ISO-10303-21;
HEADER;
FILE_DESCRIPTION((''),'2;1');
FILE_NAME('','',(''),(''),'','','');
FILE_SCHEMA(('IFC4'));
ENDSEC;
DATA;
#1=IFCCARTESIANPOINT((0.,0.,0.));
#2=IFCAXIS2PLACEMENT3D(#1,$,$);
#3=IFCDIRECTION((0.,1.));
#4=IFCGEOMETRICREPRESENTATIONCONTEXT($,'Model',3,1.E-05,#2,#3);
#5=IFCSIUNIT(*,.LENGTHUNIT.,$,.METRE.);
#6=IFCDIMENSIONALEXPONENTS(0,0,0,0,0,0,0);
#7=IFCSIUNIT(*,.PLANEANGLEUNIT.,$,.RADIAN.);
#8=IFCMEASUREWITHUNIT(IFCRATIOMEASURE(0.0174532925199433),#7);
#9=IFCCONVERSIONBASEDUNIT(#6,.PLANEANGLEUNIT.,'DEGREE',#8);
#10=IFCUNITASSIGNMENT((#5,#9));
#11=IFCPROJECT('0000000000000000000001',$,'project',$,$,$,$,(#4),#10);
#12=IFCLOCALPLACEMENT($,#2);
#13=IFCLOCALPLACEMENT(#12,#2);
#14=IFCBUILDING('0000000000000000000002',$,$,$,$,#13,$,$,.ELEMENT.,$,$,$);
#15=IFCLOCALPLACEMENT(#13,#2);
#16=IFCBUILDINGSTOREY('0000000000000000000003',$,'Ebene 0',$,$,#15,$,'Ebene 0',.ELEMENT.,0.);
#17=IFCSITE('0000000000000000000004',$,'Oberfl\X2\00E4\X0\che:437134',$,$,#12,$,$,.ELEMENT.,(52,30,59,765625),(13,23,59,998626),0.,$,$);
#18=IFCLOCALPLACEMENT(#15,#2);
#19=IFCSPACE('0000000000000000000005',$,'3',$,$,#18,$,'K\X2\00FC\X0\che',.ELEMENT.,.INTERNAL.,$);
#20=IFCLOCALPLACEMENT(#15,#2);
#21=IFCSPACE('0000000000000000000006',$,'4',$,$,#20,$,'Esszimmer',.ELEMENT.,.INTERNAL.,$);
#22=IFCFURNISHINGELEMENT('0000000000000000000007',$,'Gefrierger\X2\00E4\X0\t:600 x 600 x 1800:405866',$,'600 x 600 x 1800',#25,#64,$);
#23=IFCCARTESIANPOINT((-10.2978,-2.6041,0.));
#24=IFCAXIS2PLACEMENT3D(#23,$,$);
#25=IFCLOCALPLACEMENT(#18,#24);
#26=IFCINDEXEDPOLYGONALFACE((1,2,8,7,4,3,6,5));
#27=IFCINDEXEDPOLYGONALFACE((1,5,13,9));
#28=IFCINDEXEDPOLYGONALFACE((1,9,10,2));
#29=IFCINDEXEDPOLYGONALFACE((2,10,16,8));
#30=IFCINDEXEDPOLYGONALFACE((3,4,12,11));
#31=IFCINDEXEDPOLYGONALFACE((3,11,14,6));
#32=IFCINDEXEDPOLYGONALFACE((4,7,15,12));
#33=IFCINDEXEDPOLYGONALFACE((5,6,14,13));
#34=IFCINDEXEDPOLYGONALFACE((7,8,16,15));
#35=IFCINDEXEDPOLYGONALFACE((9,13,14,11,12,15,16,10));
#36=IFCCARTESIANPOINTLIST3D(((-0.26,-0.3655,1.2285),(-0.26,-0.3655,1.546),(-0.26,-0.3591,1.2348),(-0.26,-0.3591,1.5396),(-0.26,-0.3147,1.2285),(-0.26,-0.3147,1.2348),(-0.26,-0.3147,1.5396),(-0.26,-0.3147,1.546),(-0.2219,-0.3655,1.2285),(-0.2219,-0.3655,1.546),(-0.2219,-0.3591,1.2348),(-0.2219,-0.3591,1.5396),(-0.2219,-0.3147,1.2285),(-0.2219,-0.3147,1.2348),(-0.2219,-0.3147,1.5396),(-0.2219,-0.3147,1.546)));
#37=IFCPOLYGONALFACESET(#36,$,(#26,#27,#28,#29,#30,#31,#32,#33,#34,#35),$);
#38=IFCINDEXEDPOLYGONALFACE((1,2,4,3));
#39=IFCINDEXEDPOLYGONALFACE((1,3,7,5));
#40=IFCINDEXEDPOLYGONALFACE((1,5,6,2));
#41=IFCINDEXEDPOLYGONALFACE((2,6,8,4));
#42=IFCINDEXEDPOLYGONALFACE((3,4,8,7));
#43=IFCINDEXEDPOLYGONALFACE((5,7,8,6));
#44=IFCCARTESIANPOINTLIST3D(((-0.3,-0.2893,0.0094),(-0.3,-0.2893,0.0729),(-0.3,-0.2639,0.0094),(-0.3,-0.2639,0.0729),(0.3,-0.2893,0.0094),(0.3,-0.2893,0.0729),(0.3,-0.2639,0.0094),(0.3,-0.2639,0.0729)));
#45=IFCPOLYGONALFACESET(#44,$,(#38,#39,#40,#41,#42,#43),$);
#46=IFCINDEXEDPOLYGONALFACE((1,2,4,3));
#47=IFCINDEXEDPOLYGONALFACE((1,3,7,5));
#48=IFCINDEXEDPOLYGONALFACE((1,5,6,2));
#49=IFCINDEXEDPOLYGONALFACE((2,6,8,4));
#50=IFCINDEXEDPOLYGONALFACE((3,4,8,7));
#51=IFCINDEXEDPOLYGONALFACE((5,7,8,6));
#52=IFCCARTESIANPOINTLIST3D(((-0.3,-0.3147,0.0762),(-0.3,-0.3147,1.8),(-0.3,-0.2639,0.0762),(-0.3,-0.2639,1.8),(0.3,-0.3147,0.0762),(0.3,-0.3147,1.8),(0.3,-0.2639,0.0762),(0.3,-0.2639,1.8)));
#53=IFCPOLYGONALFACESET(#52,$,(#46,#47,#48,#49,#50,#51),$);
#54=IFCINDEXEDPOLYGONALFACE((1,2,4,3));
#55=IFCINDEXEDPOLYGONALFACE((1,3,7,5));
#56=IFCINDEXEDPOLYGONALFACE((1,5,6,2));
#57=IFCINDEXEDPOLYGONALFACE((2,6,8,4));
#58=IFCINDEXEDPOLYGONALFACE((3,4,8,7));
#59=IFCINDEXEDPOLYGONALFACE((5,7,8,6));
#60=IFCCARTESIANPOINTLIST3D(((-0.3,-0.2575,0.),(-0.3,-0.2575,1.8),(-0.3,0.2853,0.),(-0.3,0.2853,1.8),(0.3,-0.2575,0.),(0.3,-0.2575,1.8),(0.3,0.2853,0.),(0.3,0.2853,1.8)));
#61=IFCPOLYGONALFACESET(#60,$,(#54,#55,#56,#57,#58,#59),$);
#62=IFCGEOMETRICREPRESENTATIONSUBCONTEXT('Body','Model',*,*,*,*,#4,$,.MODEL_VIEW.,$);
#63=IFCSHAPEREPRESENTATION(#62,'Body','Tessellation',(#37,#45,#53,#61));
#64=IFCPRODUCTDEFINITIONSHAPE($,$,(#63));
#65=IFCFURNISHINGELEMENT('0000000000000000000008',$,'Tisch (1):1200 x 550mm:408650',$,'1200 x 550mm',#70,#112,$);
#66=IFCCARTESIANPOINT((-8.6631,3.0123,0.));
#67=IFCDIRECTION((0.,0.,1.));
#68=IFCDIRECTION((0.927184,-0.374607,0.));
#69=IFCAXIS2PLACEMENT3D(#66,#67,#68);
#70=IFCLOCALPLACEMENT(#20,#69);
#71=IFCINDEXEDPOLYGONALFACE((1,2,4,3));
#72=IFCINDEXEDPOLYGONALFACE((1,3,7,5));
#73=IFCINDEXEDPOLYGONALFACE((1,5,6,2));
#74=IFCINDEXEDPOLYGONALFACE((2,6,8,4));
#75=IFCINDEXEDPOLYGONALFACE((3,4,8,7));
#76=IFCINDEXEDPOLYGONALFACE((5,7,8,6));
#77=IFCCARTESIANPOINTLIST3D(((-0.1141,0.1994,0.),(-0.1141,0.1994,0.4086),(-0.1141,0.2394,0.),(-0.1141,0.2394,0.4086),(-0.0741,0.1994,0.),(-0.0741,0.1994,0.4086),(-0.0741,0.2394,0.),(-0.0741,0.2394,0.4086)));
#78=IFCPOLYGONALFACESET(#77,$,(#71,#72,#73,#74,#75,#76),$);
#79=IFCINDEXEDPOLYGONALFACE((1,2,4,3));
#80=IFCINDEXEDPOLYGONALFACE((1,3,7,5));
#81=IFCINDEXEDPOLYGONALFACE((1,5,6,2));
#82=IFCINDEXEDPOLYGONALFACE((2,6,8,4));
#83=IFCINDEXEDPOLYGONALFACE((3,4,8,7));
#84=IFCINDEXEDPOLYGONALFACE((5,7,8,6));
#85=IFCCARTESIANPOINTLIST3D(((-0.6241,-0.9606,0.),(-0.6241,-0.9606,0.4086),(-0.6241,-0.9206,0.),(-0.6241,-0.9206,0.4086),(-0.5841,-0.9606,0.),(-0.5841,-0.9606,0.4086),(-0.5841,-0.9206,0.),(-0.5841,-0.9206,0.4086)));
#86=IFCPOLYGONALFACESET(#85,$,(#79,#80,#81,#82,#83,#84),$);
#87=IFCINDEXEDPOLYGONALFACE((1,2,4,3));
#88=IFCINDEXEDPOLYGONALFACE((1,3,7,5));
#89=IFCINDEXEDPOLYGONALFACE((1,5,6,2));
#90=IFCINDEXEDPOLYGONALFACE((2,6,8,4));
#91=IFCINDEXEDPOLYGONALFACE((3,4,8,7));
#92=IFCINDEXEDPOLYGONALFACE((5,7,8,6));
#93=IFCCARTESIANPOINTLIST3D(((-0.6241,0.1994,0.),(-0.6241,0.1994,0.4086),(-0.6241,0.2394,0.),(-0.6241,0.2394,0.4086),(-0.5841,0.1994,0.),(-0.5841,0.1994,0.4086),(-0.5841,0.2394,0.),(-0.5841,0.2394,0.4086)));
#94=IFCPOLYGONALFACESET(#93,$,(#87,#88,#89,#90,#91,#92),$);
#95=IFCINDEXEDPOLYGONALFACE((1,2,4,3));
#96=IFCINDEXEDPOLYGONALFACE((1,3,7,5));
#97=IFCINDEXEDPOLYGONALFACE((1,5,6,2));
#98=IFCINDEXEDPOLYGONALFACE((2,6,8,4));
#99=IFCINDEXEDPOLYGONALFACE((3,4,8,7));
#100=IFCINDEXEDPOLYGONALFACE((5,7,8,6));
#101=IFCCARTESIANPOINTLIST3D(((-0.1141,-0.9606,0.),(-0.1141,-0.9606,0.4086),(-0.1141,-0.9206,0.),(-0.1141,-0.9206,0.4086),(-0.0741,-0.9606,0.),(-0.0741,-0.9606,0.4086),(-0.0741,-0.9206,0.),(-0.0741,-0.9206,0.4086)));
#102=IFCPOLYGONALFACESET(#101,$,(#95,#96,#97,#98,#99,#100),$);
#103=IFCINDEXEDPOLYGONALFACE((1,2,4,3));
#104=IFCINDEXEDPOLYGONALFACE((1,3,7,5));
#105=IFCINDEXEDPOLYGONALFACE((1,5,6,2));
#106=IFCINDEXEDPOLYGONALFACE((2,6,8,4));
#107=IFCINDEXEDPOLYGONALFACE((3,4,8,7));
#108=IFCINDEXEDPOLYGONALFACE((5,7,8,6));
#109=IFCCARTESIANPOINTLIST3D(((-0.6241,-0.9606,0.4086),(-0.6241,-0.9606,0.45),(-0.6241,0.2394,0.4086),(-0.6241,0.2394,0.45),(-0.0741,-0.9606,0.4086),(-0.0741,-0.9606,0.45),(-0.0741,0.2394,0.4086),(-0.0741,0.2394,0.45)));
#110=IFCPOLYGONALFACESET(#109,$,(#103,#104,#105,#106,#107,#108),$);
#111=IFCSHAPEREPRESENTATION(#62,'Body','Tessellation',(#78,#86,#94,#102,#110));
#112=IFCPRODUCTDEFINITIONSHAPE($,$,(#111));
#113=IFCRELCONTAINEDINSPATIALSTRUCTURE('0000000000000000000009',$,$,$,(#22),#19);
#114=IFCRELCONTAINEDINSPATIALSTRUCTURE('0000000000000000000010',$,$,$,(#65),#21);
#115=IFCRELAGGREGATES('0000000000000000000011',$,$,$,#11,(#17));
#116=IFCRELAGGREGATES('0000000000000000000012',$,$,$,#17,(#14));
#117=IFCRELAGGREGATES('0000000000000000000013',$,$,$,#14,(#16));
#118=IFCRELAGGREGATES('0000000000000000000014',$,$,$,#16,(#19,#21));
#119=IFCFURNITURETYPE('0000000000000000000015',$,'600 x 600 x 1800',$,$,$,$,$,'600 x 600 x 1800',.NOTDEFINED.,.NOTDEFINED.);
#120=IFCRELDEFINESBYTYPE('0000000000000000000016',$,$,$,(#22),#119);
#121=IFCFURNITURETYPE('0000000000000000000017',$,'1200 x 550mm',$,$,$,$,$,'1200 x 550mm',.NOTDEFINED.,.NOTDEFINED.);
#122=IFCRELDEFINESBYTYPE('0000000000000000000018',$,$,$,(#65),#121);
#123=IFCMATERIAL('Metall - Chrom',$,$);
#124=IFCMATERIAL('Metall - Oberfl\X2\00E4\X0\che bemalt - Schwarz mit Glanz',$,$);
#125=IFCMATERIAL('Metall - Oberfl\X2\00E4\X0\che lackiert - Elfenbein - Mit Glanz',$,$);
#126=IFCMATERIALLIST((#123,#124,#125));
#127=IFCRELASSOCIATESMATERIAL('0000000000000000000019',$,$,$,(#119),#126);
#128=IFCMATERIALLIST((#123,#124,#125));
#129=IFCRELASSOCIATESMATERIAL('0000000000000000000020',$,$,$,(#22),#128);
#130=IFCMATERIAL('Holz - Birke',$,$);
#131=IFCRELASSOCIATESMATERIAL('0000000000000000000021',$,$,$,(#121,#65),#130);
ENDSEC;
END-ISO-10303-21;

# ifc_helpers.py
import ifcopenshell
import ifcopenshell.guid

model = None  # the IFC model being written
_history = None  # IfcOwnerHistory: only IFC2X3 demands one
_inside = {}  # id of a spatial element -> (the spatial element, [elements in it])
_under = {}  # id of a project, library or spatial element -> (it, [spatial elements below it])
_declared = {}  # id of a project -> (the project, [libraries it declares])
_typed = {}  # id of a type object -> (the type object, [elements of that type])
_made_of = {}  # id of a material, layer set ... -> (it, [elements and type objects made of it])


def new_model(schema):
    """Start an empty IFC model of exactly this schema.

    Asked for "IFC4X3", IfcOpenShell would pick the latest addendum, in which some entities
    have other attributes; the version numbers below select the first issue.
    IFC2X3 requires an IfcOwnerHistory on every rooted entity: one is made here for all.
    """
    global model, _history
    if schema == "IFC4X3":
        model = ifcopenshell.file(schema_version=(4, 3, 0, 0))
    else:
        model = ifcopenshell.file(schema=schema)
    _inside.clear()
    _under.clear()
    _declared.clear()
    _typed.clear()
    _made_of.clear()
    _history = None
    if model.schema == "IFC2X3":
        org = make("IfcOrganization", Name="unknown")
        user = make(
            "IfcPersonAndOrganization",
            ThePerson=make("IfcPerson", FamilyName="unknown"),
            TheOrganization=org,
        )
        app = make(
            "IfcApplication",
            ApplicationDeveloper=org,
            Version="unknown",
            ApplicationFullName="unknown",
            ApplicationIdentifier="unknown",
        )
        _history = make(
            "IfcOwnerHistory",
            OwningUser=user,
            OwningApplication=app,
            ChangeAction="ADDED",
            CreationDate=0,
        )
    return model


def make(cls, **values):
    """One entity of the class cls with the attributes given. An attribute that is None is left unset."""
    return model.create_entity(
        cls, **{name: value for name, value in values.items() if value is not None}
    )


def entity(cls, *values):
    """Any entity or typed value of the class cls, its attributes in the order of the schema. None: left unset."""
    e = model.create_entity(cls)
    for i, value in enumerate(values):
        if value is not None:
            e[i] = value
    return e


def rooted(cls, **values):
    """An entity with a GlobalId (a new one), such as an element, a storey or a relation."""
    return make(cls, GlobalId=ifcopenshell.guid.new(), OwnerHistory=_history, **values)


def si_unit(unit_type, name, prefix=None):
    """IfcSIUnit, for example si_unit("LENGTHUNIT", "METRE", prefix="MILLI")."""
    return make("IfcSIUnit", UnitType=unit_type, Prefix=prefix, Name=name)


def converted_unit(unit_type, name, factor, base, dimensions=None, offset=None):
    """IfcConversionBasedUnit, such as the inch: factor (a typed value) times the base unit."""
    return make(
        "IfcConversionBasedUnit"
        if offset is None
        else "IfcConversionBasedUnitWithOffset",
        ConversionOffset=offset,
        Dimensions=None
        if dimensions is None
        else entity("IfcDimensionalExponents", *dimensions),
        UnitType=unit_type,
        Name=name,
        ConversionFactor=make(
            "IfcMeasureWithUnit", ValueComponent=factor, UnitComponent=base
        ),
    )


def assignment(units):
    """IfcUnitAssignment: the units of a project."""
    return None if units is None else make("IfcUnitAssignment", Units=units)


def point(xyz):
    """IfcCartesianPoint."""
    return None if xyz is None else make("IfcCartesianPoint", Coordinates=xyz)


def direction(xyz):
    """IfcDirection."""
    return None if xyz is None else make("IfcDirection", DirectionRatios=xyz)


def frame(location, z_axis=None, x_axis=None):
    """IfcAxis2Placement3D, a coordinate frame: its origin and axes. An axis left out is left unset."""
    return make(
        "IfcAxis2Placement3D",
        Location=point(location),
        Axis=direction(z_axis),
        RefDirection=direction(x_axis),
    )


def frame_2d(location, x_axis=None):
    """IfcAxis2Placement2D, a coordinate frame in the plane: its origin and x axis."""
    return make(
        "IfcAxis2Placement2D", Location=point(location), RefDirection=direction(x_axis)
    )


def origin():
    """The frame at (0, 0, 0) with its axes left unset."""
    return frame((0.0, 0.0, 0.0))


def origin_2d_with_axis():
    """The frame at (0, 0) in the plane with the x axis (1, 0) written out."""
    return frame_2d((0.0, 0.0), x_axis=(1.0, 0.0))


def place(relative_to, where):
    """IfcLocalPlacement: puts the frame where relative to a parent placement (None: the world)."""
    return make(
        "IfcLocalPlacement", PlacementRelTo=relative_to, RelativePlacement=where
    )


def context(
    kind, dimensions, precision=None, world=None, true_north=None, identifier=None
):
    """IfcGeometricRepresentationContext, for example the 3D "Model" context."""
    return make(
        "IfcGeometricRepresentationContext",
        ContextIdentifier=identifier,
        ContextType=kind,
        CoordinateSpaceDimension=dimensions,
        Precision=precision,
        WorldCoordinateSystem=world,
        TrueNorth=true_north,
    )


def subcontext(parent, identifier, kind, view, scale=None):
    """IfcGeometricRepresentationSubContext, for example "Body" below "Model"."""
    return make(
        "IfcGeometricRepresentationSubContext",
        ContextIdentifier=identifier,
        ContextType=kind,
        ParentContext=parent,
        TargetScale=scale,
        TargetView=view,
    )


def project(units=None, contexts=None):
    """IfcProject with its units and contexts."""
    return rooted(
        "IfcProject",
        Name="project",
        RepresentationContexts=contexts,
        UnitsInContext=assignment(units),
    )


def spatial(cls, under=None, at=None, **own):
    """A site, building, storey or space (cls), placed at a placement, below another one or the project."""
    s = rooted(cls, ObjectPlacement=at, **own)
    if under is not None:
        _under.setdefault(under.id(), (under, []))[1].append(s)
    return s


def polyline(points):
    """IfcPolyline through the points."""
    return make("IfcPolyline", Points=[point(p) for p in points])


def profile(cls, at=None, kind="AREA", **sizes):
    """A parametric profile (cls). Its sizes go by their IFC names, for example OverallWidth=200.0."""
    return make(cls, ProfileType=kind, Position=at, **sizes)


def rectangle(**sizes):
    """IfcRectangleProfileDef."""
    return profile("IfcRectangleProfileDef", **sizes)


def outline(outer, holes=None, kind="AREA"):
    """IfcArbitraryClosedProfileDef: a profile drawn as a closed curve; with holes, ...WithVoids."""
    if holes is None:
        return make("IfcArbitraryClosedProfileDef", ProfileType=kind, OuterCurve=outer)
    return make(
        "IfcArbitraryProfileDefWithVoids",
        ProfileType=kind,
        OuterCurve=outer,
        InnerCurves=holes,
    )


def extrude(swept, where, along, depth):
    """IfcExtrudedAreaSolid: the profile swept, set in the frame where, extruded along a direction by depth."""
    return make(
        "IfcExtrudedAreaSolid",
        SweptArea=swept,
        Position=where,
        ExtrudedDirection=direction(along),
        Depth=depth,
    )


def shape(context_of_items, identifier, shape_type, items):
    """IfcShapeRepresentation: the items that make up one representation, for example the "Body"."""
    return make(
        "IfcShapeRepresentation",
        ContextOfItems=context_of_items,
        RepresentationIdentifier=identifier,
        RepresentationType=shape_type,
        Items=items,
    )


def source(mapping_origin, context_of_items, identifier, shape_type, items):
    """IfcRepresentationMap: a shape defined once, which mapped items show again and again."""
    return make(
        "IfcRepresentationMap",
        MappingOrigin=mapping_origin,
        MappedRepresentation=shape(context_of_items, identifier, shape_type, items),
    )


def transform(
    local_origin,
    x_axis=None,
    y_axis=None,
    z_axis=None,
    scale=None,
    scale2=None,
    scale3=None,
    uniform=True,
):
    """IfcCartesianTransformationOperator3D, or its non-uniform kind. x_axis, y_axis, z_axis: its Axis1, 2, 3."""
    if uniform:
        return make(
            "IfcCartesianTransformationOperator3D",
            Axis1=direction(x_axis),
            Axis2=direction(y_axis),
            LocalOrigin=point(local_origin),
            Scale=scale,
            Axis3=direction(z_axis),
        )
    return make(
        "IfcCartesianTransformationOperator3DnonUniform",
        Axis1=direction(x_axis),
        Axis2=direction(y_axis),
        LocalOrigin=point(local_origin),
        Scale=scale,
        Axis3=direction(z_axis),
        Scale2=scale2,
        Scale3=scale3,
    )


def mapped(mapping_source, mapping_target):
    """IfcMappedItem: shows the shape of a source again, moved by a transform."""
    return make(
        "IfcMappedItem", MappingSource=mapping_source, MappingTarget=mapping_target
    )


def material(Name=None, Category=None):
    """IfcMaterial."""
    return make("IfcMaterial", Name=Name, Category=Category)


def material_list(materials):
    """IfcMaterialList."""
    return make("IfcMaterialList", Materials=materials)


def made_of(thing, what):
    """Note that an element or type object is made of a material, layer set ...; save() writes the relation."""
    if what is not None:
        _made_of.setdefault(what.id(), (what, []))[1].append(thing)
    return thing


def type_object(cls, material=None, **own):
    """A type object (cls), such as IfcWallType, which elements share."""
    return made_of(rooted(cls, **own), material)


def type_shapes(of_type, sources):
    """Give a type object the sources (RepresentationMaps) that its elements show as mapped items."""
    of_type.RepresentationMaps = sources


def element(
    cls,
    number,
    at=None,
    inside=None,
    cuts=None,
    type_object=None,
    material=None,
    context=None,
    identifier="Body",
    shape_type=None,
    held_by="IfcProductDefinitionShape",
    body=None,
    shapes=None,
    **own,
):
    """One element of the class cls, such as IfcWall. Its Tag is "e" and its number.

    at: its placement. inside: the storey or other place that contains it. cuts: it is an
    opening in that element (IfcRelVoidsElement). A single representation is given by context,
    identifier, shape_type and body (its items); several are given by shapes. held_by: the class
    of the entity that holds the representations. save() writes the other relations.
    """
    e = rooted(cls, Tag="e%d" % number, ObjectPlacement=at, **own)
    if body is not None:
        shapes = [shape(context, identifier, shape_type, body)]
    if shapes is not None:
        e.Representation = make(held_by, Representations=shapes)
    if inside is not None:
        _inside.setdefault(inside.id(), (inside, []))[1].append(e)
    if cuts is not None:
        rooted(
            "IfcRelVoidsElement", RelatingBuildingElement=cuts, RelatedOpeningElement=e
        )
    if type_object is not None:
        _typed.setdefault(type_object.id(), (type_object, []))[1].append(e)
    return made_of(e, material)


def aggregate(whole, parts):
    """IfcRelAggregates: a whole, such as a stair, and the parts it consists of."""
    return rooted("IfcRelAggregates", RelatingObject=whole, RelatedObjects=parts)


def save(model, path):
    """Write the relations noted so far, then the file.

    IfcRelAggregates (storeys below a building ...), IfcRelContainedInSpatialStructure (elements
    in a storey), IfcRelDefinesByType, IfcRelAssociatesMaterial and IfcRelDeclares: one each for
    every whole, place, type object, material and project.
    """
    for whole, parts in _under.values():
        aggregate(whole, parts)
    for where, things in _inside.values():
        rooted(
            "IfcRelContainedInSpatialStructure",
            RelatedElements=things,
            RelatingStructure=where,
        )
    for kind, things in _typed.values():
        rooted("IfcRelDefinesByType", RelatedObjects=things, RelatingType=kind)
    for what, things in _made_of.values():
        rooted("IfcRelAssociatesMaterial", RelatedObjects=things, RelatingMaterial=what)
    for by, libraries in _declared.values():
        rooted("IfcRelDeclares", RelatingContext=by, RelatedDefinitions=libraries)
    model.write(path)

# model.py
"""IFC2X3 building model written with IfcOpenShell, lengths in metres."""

from ifc_helpers import new_model, entity, si_unit, converted_unit, direction, frame, frame_2d, origin, origin_2d_with_axis, place, context, subcontext, project, spatial, polyline, rectangle, outline, extrude, source, transform, mapped, material, material_list, type_object, type_shapes, element, save


model = new_model("IFC2X3")

# Units and contexts
model_context = context("Model", 3, precision=1e-05, world=origin(), true_north=direction((0.0, 1.0)))
body_context = subcontext(model_context, "Body", "Model", "MODEL_VIEW")
ifc_project = project(units=[si_unit("LENGTHUNIT", "METRE"), converted_unit("PLANEANGLEUNIT", "DEGREE", entity("IfcRatioMeasure", 0.0174532925199433), si_unit("PLANEANGLEUNIT", "RADIAN"), dimensions=[0, 0, 0, 0, 0, 0, 0])], contexts=[model_context])

# Site, building, storey
site_placement = place(None, origin())
site = spatial("IfcSite", under=ifc_project, at=site_placement, Name="Oberfläche:437134", CompositionType="ELEMENT", RefLatitude=(52, 30, 59, 765625), RefLongitude=(13, 23, 59, 998626), RefElevation=0.0)
building_placement = place(site_placement, origin())
building = spatial("IfcBuilding", under=site, at=building_placement, CompositionType="ELEMENT")
storey_placement = place(building_placement, origin())
storey = spatial("IfcBuildingStorey", under=building, at=storey_placement, Name="Ebene 0", LongName="Ebene 0", CompositionType="ELEMENT", Elevation=0.0)

# Shared definitions
space_1_placement = place(storey_placement, origin())
space_1 = spatial("IfcSpace", under=storey, at=space_1_placement, Name="3", LongName="Küche", CompositionType="ELEMENT", InteriorOrExteriorSpace="INTERNAL")

# Furnishing element
ifc_material_1 = material(Name="Metall - Chrom")
ifc_material_2 = material(Name="Metall - Oberfläche bemalt - Schwarz mit Glanz")
ifc_material_3 = material(Name="Metall - Oberfläche lackiert - Elfenbein - Mit Glanz")
ifc_material_list_1 = material_list([ifc_material_1, ifc_material_2, ifc_material_3])
ifc_material_list_2 = material_list([ifc_material_1, ifc_material_2, ifc_material_3])
furniture_type_1 = type_object("IfcFurnitureType", Name="600 x 600 x 1800", ElementType="600 x 600 x 1800", material=ifc_material_list_2)
shared_shape_1 = source(origin(), body_context, "Body", "SweptSolid", [
    extrude(outline(polyline([(0.1524, -0.0238), (0.1587, -0.0238), (0.1587, 0.027), (-0.1587, 0.027), (-0.1587, -0.0238), (-0.1524, -0.0238), (-0.1524, 0.0206), (0.1524, 0.0206), (0.1524, -0.0238)])), frame((-0.26, -0.3385, 1.3873), z_axis=(1.0, 0.0, 0.0), x_axis=(0.0, 0.0, 1.0)), (0.0, 0.0, 1.0), 0.0381),
    extrude(rectangle(XDim=0.6, YDim=0.0254, at=frame_2d((0.0, 0.0), x_axis=(1.0, 0.0))), frame((0.0, -0.2766, 0.0094), z_axis=(0.0, 0.0, 1.0), x_axis=(-1.0, 0.0, 0.0)), (0.0, 0.0, 1.0), 0.0635),
    extrude(rectangle(XDim=0.6, YDim=0.0508, at=origin_2d_with_axis()), frame((0.0, -0.2893, 0.0762), z_axis=(0.0, 0.0, 1.0), x_axis=(-1.0, 0.0, 0.0)), (0.0, 0.0, 1.0), 1.7238),
    extrude(rectangle(XDim=0.6, YDim=0.5429, at=frame_2d((0.0, 0.0), x_axis=(1.0, 0.0))), frame((0.0, 0.0139, 0.0), z_axis=(0.0, 0.0, 1.0), x_axis=(-1.0, 0.0, 0.0)), (0.0, 0.0, 1.0), 1.8),
])
type_shapes(furniture_type_1, [shared_shape_1])
furnishing_1_placement = place(space_1_placement, frame((-10.2978, -2.6041, 0.0)))
element("IfcFurnishingElement", 1, at=furnishing_1_placement, inside=space_1, type_object=furniture_type_1, material=ifc_material_list_1, Name="Gefriergerät:600 x 600 x 1800:405866", ObjectType="600 x 600 x 1800", context=body_context, shape_type="MappedRepresentation", body=[
    mapped(shared_shape_1, transform((0.0, 0.0, 0.0), scale=1.0)),
])

# Shared definitions
space_2_placement = place(storey_placement, origin())
space_2 = spatial("IfcSpace", under=storey, at=space_2_placement, Name="4", LongName="Esszimmer", CompositionType="ELEMENT", InteriorOrExteriorSpace="INTERNAL")

# Furnishing element
ifc_material_4 = material(Name="Holz - Birke")
furniture_type_2 = type_object("IfcFurnitureType", Name="1200 x 550mm", ElementType="1200 x 550mm", material=ifc_material_4)
shared_shape_2 = source(origin(), body_context, "Body", "SweptSolid", [
    extrude(rectangle(XDim=0.04, YDim=0.04, at=origin_2d_with_axis()), frame((-0.0941, 0.2194, 0.0), z_axis=(0.0, 0.0, 1.0), x_axis=(-1.0, 0.0, 0.0)), (0.0, 0.0, 1.0), 0.4086),
    extrude(rectangle(XDim=0.04, YDim=0.04, at=frame_2d((0.0, 0.0), x_axis=(1.0, 0.0))), frame((-0.6041, -0.9406, 0.0), z_axis=(0.0, 0.0, 1.0), x_axis=(0.0, -1.0, 0.0)), (0.0, 0.0, 1.0), 0.4086),
    extrude(rectangle(XDim=0.04, YDim=0.04, at=origin_2d_with_axis()), frame((-0.6041, 0.2194, 0.0), z_axis=(0.0, 0.0, 1.0), x_axis=(-1.0, 0.0, 0.0)), (0.0, 0.0, 1.0), 0.4086),
    extrude(rectangle(XDim=0.04, YDim=0.04, at=origin_2d_with_axis()), frame((-0.0941, -0.9406, 0.0), z_axis=(0.0, 0.0, 1.0), x_axis=(-1.0, 0.0, 0.0)), (0.0, 0.0, 1.0), 0.4086),
    extrude(rectangle(XDim=0.55, YDim=1.2, at=origin_2d_with_axis()), frame((-0.3491, -0.3606, 0.4086), z_axis=(0.0, 0.0, 1.0), x_axis=(-1.0, 0.0, 0.0)), (0.0, 0.0, 1.0), 0.0414),
])
type_shapes(furniture_type_2, [shared_shape_2])
furnishing_2_placement = place(space_2_placement, frame((-8.6631, 3.0123, 0.0), z_axis=(0.0, 0.0, 1.0), x_axis=(0.927184, -0.374607, 0.0)))
element("IfcFurnishingElement", 2, at=furnishing_2_placement, inside=space_2, type_object=furniture_type_2, material=ifc_material_4, Name="Tisch (1):1200 x 550mm:408650", ObjectType="1200 x 550mm", context=body_context, shape_type="MappedRepresentation", body=[
    mapped(shared_shape_2, transform((0.0, 0.0, 0.0), scale=1.0)),
])

save(model, "model.ifc")
